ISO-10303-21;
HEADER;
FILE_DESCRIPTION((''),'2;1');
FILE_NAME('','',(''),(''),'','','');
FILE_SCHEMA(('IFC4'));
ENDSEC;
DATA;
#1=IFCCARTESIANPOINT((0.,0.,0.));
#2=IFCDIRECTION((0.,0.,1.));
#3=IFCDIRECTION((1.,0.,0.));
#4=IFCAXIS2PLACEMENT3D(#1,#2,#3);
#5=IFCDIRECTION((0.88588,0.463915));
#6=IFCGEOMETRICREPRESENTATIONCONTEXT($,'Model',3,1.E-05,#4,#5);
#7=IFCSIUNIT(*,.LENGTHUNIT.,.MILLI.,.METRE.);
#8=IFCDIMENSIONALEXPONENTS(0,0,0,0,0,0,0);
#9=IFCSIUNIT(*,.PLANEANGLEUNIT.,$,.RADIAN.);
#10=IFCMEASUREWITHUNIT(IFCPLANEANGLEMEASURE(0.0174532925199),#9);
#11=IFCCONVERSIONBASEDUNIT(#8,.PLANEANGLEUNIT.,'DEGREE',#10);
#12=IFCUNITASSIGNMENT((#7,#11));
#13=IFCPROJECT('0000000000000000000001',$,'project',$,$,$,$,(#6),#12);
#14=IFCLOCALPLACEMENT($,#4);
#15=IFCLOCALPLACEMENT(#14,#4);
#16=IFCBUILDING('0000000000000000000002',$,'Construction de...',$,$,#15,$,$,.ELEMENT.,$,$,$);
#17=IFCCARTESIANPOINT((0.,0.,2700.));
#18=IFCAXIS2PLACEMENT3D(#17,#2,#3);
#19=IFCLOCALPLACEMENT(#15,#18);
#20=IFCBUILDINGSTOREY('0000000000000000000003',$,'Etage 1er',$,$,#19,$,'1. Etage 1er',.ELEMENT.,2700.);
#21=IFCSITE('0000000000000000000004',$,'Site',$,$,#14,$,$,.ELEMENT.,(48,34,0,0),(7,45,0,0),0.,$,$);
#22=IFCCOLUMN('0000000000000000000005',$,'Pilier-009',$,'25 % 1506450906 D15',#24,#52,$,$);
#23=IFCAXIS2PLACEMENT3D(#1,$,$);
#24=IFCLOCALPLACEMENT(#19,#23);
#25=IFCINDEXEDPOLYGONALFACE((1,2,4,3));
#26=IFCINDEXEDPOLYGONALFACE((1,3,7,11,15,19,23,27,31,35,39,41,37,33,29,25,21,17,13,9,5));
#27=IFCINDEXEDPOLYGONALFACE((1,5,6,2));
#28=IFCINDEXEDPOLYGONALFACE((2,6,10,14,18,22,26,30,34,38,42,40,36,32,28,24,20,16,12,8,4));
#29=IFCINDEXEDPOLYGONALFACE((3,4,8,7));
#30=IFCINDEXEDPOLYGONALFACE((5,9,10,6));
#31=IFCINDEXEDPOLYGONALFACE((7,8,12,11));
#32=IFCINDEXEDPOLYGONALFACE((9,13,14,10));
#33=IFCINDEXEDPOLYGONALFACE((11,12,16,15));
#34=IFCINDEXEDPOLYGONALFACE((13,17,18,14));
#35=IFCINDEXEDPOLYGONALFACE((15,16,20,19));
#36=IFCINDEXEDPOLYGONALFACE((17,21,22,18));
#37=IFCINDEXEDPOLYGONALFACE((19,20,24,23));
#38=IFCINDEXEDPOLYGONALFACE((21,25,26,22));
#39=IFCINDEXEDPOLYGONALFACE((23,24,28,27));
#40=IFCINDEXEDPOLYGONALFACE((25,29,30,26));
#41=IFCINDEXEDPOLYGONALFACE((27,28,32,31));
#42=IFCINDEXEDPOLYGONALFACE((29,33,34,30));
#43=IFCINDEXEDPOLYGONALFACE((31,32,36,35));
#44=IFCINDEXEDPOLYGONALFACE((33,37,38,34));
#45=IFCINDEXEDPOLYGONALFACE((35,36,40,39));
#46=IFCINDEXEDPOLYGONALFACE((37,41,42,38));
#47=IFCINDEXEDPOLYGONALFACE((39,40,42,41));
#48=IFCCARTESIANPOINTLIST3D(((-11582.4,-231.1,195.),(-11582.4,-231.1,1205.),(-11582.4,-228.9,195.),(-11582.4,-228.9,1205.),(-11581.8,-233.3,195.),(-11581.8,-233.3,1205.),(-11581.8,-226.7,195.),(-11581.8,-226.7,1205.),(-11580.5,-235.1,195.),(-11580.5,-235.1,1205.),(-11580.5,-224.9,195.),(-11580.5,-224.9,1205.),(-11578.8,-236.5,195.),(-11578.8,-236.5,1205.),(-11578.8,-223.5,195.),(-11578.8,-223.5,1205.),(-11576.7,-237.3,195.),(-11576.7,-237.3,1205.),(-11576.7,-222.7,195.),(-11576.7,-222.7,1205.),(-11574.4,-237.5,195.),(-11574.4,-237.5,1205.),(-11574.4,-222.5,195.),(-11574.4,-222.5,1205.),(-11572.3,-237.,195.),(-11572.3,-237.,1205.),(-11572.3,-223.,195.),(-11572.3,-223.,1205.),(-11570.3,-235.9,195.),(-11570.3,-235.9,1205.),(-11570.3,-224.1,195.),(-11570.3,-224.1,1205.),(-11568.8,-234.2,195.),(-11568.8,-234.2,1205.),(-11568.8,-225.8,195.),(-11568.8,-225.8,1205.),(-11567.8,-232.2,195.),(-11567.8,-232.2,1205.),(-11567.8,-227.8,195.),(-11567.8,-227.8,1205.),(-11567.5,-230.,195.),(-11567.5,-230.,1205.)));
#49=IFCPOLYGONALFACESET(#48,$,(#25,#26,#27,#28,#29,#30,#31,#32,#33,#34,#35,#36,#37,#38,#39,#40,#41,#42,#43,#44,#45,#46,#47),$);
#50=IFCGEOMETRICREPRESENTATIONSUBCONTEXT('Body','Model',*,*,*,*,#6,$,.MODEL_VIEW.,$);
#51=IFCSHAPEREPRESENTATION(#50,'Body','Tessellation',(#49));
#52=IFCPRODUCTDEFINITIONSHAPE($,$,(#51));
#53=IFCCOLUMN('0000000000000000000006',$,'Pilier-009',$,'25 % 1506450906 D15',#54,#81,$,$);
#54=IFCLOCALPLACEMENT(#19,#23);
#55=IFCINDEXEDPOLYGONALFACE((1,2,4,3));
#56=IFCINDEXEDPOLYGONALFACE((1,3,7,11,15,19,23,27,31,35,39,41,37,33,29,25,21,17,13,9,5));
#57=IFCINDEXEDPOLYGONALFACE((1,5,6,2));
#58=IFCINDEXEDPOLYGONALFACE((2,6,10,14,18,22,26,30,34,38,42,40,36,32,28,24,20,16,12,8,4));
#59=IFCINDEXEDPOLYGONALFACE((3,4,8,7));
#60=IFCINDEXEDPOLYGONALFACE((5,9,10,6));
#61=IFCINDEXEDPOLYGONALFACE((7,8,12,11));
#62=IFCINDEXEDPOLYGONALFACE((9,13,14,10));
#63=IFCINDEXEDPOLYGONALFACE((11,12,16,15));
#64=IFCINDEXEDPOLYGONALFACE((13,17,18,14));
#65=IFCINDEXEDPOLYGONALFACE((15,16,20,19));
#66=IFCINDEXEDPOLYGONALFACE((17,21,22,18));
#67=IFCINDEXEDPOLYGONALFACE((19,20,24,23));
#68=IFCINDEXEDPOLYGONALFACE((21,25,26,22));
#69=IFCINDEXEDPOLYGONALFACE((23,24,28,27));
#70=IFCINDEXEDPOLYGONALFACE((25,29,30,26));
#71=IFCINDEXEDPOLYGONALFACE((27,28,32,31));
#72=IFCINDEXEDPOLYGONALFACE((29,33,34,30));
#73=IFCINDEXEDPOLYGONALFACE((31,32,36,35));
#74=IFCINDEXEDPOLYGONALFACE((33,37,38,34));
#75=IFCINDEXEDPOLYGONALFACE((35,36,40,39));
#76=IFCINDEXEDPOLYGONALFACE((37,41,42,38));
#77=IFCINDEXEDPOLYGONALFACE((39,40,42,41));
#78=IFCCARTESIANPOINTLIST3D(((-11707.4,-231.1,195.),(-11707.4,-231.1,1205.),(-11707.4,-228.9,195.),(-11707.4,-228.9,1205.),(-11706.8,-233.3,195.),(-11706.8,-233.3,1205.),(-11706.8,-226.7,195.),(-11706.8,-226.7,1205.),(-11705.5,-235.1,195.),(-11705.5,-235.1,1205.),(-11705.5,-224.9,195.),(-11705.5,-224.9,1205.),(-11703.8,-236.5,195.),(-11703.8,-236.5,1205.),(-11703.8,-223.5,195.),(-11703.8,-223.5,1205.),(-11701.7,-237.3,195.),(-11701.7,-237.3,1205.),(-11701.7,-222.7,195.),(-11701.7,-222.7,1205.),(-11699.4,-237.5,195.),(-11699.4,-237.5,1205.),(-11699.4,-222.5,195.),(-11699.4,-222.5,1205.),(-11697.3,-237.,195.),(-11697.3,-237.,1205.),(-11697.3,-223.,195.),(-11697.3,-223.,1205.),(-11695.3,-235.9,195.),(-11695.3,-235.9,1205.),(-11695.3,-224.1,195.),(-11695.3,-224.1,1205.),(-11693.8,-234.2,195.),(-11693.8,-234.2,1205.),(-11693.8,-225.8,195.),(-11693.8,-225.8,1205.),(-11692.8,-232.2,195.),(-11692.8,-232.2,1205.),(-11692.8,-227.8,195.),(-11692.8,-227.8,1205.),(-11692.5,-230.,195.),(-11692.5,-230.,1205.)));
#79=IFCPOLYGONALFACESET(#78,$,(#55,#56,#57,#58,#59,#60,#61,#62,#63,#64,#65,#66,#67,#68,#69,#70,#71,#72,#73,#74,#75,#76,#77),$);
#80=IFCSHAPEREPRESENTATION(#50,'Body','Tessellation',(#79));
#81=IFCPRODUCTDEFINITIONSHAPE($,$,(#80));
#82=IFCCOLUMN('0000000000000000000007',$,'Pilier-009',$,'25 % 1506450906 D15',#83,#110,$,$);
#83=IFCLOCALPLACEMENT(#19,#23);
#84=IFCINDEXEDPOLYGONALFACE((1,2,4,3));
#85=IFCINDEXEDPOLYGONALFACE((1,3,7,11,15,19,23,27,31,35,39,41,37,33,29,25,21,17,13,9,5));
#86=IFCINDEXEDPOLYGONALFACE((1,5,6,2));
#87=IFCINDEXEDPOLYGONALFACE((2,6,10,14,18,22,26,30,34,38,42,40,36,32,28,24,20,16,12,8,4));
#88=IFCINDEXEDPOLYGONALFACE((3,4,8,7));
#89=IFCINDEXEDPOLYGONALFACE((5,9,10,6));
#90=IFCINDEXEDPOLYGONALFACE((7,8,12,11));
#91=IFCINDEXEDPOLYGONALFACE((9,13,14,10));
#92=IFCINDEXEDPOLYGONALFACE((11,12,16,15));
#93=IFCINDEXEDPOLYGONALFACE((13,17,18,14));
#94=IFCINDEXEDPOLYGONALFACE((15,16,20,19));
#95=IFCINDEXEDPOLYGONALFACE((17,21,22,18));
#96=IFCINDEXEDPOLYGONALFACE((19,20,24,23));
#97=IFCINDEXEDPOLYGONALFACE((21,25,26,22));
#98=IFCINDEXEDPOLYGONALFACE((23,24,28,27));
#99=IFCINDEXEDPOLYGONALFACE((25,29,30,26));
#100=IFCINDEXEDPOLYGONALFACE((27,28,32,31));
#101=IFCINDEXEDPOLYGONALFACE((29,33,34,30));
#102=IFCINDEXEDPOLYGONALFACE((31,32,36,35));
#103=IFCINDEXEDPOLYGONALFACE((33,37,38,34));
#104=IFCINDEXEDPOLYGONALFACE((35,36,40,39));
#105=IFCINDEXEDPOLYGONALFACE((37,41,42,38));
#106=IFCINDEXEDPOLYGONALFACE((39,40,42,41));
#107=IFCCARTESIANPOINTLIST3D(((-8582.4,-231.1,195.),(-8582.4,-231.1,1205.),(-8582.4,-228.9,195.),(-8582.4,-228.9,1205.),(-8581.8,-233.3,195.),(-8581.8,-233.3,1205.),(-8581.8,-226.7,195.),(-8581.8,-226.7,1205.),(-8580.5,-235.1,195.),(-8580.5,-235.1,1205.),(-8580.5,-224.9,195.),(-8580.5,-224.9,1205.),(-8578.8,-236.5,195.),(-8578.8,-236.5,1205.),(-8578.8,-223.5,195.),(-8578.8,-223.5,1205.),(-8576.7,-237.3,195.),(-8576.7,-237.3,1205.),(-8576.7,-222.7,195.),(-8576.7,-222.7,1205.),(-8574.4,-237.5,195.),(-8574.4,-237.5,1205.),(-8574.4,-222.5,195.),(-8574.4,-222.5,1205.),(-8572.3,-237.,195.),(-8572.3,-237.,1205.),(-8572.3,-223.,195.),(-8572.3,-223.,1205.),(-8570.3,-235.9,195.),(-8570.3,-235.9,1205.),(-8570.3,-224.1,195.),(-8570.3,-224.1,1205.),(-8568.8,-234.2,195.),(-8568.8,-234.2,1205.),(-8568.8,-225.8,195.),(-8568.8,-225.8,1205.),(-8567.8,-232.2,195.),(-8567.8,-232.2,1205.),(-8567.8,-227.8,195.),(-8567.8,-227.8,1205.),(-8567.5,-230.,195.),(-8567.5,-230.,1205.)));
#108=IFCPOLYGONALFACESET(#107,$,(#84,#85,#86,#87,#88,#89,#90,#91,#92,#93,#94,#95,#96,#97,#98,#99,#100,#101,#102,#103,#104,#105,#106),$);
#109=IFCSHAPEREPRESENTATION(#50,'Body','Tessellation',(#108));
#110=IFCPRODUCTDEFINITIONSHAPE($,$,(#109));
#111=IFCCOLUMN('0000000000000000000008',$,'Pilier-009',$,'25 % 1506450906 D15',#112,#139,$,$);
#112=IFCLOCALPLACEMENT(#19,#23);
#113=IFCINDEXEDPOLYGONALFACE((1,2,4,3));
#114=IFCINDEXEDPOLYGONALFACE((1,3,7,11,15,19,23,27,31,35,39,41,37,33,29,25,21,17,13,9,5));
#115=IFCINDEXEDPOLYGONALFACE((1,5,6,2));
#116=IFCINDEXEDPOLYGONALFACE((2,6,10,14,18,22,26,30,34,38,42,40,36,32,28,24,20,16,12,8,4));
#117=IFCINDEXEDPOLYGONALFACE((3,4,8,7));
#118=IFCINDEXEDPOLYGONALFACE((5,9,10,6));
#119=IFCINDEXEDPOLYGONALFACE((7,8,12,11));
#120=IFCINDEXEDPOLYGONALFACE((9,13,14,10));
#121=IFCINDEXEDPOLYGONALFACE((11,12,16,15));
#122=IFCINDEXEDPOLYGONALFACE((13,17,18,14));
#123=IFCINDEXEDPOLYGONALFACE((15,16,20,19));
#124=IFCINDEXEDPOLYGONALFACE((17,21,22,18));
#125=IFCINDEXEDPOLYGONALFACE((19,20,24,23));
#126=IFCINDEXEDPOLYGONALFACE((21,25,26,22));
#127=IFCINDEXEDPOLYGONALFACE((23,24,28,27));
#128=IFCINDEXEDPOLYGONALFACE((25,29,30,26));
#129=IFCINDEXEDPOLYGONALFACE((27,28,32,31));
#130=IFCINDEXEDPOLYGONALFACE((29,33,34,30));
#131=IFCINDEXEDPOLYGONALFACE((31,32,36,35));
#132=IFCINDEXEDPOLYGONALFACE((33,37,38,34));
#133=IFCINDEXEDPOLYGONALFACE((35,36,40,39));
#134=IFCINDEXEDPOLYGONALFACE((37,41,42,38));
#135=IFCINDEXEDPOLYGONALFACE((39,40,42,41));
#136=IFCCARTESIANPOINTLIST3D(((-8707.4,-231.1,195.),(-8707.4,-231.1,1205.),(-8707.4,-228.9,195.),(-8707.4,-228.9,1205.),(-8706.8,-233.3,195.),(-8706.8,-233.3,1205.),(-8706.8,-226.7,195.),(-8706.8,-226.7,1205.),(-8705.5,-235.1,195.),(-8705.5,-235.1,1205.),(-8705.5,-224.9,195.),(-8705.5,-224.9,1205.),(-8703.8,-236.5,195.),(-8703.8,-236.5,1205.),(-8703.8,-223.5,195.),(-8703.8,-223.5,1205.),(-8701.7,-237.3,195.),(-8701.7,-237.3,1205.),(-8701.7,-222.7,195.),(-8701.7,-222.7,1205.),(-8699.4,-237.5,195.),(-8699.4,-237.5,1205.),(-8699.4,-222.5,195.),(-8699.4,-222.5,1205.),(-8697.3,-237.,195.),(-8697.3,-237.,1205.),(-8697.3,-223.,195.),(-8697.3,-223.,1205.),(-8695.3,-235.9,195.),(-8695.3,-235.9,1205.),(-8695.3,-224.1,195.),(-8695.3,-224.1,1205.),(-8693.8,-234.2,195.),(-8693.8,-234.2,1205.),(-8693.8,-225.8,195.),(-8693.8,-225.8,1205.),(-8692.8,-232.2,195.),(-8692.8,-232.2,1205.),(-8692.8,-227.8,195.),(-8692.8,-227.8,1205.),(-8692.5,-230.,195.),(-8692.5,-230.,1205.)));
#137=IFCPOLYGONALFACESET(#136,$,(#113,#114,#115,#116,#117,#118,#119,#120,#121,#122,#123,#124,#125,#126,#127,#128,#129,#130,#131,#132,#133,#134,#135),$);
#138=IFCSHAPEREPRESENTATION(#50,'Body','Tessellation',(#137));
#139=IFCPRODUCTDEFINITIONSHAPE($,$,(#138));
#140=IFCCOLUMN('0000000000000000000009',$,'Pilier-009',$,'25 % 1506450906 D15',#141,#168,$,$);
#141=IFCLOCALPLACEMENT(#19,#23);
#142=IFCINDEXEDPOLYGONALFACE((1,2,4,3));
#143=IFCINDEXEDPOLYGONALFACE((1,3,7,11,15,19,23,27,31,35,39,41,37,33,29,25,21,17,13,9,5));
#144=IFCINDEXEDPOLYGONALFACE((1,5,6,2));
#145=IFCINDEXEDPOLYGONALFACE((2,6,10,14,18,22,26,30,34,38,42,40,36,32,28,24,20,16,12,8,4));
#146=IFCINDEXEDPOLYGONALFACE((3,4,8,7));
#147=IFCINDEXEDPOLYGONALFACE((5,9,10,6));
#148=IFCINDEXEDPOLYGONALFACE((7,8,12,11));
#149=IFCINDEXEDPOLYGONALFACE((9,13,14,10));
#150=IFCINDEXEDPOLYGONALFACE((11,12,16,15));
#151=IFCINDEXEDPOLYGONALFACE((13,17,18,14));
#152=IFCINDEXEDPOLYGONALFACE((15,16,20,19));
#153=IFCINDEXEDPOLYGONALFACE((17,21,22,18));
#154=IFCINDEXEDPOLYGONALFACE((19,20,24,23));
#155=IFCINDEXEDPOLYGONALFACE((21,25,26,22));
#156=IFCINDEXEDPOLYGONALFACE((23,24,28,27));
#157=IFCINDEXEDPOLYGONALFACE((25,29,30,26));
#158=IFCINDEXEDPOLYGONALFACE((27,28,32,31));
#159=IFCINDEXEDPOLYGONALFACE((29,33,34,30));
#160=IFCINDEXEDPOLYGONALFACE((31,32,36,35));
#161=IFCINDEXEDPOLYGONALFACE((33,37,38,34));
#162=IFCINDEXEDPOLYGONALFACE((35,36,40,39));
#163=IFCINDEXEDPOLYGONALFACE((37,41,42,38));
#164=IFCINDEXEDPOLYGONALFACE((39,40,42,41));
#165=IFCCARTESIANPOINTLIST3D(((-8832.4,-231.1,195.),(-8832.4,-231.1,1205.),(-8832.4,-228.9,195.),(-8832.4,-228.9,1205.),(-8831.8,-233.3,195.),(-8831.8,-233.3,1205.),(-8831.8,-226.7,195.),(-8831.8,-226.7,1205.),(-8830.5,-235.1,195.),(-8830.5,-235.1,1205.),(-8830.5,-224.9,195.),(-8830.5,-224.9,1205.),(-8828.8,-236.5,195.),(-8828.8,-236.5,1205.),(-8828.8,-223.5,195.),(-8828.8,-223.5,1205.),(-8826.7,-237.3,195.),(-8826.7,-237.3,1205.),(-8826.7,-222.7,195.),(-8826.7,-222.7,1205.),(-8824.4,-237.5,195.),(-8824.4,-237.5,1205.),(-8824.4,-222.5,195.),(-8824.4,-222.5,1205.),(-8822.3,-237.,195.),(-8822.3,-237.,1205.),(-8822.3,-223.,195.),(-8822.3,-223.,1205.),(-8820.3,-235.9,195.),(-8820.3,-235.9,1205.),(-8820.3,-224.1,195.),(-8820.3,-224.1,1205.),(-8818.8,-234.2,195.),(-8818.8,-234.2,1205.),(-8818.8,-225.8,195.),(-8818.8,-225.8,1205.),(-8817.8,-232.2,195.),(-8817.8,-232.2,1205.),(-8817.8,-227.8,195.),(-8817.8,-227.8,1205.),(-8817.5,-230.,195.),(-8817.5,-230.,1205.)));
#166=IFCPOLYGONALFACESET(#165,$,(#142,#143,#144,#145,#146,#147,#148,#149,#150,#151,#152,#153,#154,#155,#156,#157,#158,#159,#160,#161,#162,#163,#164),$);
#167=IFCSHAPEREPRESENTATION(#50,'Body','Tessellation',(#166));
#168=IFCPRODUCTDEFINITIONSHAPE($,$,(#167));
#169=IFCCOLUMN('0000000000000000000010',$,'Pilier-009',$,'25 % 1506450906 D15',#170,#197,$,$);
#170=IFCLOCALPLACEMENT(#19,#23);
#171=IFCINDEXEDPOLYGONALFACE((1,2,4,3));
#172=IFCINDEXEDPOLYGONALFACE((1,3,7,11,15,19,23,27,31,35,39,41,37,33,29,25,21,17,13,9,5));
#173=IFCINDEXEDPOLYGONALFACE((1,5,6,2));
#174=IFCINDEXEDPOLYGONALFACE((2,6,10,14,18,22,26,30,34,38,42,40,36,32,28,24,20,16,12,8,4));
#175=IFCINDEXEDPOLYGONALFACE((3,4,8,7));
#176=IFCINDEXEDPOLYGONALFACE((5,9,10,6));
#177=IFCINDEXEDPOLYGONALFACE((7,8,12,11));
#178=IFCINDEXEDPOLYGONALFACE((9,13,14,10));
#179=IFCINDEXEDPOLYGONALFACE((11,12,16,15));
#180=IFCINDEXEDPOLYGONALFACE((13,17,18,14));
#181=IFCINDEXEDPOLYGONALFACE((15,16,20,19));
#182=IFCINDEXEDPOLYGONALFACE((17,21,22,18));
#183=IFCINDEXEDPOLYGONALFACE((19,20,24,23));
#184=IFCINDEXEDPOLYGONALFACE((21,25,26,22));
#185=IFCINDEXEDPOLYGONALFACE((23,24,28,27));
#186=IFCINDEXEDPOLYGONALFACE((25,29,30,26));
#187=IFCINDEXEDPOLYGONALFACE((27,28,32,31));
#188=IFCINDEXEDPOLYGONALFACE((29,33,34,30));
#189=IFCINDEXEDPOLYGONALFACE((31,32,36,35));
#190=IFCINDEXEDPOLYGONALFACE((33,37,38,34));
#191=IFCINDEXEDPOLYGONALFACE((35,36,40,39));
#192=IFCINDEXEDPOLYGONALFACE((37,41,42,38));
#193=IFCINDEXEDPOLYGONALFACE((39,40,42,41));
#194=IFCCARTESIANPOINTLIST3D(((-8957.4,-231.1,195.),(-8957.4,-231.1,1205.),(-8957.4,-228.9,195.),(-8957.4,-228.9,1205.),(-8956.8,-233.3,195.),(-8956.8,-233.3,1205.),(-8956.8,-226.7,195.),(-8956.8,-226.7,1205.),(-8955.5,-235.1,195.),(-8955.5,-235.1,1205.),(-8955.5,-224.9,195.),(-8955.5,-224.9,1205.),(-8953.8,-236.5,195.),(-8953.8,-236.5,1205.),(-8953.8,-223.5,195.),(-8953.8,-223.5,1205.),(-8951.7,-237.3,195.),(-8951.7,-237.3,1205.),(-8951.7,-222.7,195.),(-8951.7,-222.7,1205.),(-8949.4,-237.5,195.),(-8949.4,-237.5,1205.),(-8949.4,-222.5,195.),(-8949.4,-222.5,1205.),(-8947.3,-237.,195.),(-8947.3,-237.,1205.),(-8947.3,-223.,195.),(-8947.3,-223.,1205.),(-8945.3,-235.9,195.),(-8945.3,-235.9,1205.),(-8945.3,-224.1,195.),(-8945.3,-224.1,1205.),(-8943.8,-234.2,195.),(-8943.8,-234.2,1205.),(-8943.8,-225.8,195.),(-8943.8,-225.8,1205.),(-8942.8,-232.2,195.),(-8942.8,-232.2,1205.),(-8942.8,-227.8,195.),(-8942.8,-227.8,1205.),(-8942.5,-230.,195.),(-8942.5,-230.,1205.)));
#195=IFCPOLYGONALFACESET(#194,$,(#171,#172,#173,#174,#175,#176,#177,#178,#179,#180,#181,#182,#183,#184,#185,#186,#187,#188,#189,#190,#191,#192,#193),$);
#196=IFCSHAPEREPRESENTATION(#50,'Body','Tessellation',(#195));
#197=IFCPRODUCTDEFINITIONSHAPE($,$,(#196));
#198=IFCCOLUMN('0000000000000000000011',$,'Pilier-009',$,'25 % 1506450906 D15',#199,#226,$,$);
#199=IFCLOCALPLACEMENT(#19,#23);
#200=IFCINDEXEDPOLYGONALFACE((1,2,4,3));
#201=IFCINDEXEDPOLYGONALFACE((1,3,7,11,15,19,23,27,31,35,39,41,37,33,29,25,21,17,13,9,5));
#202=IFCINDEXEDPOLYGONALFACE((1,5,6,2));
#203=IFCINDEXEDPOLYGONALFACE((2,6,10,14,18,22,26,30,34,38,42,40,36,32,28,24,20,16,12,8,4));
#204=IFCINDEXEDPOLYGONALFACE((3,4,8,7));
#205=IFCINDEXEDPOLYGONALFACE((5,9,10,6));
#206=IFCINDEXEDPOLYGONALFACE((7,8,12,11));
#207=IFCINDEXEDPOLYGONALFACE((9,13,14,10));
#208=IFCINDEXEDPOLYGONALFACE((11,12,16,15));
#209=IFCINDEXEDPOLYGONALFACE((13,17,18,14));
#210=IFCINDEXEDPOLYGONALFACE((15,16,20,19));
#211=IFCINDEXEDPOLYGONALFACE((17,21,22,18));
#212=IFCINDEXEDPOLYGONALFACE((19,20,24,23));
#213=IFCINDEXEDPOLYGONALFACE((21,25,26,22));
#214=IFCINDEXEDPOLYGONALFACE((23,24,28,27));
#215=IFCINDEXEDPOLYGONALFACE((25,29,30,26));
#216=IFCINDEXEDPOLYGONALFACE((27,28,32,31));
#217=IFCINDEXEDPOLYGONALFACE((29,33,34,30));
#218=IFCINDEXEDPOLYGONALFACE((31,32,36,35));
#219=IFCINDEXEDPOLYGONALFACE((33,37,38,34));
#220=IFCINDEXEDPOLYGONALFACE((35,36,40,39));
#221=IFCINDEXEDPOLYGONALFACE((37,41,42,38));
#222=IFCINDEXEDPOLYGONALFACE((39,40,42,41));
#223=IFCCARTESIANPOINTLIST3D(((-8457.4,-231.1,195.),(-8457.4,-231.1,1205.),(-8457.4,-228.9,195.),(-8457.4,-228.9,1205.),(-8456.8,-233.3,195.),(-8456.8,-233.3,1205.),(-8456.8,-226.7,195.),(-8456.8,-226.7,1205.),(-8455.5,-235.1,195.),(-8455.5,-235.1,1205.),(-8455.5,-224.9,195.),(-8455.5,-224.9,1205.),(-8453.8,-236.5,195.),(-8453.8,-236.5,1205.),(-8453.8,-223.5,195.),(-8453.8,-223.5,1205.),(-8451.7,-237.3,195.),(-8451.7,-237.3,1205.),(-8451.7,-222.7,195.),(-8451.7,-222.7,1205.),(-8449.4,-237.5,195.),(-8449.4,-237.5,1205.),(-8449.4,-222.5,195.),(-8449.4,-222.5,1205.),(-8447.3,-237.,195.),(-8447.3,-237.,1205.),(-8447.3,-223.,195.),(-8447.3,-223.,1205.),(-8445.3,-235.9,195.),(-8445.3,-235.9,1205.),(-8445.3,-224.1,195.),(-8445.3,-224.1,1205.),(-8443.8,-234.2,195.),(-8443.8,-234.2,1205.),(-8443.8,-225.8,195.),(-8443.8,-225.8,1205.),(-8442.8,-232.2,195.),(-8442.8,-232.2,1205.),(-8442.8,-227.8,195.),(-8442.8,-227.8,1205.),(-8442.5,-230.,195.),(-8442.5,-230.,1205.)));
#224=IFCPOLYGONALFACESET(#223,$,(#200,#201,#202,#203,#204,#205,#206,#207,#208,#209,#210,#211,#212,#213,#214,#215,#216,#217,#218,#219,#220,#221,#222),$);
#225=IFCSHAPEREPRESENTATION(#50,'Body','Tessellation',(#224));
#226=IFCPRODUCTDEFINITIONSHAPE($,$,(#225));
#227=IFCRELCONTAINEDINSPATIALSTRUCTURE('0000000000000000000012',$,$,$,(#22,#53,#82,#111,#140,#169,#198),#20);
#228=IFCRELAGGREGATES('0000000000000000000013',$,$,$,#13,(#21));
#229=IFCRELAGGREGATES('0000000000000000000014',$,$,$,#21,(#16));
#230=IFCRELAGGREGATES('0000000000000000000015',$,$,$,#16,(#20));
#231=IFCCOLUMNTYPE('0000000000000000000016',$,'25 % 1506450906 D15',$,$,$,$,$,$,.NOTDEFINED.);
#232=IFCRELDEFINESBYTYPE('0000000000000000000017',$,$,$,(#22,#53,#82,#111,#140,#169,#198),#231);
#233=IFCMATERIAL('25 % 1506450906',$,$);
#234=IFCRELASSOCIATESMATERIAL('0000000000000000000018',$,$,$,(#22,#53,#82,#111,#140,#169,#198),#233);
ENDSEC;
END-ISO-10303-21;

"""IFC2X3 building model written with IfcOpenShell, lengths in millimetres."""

from ifc_helpers import new_model, entity, si_unit, converted_unit, direction, frame, origin_with_axes, origin_2d_with_axis, place, context, subcontext, project, spatial, circle, extrude, material, type_object, element, save


model = new_model("IFC2X3")

# Units and contexts
model_context = context("Model", 3, precision=1e-05, world=origin_with_axes(), true_north=direction((0.88588, 0.463915)))
body_context = subcontext(model_context, "Body", "Model", "MODEL_VIEW")
ifc_project = project(units=[si_unit("LENGTHUNIT", "METRE", prefix="MILLI"), converted_unit("PLANEANGLEUNIT", "DEGREE", entity("IfcPlaneAngleMeasure", 0.0174532925199), si_unit("PLANEANGLEUNIT", "RADIAN"), dimensions=[0, 0, 0, 0, 0, 0, 0])], contexts=[model_context])

# Site, building, storey
site_placement = place(None, origin_with_axes())
site = spatial("IfcSite", under=ifc_project, at=site_placement, Name="Site", CompositionType="ELEMENT", RefLatitude=(48, 34, 0, 0), RefLongitude=(7, 45, 0, 0), RefElevation=0.0)
building_placement = place(site_placement, origin_with_axes())
building = spatial("IfcBuilding", under=site, at=building_placement, Name="Construction de...", CompositionType="ELEMENT")
storey_placement = place(building_placement, frame((0.0, 0.0, 2700.0), z_axis=(0.0, 0.0, 1.0), x_axis=(1.0, 0.0, 0.0)))
storey = spatial("IfcBuildingStorey", under=building, at=storey_placement, Name="Etage 1er", LongName="1. Etage 1er", CompositionType="ELEMENT", Elevation=2700.0)

# Columns
ifc_material = material(Name="25 % 1506450906")
column_type = type_object("IfcColumnType", Name="25 % 1506450906 D15", PredefinedType="NOTDEFINED")
for number, where, z_axis, x_axis, name in (
    (1, (-11575.0, -230.0, 195.0), (0.0, 0.0, 1.0), (1.0, 0.0, 0.0), "Pilier-009"),
    (2, (-11700.0, -230.0, 195.0), (0.0, 0.0, 1.0), (1.0, 0.0, 0.0), "Pilier-009"),
    (3, (-8575.0, -230.0, 195.0), (0.0, 0.0, 1.0), (1.0, 0.0, 0.0), "Pilier-009"),
    (4, (-8700.0, -230.0, 195.0), (0.0, 0.0, 1.0), (1.0, 0.0, 0.0), "Pilier-009"),
    (5, (-8825.0, -230.0, 195.0), (0.0, 0.0, 1.0), (1.0, 0.0, 0.0), "Pilier-009"),
    (6, (-8950.0, -230.0, 195.0), (0.0, 0.0, 1.0), (1.0, 0.0, 0.0), "Pilier-009"),
    (7, (-8450.0, -230.0, 195.0), (0.0, 0.0, 1.0), (1.0, 0.0, 0.0), "Pilier-009"),
):
    element("IfcColumn", number, at=place(storey_placement, frame(where, z_axis=z_axis, x_axis=x_axis)), inside=storey, type_object=column_type, material=ifc_material, Name=name, ObjectType="25 % 1506450906 D15", context=body_context, shape_type="SweptSolid", body=[
        extrude(circle(Radius=7.5, at=origin_2d_with_axis()), origin_with_axes(), (0.0, 0.0, 1.0), 1010.0),
    ])

save(model, "model.ifc")
